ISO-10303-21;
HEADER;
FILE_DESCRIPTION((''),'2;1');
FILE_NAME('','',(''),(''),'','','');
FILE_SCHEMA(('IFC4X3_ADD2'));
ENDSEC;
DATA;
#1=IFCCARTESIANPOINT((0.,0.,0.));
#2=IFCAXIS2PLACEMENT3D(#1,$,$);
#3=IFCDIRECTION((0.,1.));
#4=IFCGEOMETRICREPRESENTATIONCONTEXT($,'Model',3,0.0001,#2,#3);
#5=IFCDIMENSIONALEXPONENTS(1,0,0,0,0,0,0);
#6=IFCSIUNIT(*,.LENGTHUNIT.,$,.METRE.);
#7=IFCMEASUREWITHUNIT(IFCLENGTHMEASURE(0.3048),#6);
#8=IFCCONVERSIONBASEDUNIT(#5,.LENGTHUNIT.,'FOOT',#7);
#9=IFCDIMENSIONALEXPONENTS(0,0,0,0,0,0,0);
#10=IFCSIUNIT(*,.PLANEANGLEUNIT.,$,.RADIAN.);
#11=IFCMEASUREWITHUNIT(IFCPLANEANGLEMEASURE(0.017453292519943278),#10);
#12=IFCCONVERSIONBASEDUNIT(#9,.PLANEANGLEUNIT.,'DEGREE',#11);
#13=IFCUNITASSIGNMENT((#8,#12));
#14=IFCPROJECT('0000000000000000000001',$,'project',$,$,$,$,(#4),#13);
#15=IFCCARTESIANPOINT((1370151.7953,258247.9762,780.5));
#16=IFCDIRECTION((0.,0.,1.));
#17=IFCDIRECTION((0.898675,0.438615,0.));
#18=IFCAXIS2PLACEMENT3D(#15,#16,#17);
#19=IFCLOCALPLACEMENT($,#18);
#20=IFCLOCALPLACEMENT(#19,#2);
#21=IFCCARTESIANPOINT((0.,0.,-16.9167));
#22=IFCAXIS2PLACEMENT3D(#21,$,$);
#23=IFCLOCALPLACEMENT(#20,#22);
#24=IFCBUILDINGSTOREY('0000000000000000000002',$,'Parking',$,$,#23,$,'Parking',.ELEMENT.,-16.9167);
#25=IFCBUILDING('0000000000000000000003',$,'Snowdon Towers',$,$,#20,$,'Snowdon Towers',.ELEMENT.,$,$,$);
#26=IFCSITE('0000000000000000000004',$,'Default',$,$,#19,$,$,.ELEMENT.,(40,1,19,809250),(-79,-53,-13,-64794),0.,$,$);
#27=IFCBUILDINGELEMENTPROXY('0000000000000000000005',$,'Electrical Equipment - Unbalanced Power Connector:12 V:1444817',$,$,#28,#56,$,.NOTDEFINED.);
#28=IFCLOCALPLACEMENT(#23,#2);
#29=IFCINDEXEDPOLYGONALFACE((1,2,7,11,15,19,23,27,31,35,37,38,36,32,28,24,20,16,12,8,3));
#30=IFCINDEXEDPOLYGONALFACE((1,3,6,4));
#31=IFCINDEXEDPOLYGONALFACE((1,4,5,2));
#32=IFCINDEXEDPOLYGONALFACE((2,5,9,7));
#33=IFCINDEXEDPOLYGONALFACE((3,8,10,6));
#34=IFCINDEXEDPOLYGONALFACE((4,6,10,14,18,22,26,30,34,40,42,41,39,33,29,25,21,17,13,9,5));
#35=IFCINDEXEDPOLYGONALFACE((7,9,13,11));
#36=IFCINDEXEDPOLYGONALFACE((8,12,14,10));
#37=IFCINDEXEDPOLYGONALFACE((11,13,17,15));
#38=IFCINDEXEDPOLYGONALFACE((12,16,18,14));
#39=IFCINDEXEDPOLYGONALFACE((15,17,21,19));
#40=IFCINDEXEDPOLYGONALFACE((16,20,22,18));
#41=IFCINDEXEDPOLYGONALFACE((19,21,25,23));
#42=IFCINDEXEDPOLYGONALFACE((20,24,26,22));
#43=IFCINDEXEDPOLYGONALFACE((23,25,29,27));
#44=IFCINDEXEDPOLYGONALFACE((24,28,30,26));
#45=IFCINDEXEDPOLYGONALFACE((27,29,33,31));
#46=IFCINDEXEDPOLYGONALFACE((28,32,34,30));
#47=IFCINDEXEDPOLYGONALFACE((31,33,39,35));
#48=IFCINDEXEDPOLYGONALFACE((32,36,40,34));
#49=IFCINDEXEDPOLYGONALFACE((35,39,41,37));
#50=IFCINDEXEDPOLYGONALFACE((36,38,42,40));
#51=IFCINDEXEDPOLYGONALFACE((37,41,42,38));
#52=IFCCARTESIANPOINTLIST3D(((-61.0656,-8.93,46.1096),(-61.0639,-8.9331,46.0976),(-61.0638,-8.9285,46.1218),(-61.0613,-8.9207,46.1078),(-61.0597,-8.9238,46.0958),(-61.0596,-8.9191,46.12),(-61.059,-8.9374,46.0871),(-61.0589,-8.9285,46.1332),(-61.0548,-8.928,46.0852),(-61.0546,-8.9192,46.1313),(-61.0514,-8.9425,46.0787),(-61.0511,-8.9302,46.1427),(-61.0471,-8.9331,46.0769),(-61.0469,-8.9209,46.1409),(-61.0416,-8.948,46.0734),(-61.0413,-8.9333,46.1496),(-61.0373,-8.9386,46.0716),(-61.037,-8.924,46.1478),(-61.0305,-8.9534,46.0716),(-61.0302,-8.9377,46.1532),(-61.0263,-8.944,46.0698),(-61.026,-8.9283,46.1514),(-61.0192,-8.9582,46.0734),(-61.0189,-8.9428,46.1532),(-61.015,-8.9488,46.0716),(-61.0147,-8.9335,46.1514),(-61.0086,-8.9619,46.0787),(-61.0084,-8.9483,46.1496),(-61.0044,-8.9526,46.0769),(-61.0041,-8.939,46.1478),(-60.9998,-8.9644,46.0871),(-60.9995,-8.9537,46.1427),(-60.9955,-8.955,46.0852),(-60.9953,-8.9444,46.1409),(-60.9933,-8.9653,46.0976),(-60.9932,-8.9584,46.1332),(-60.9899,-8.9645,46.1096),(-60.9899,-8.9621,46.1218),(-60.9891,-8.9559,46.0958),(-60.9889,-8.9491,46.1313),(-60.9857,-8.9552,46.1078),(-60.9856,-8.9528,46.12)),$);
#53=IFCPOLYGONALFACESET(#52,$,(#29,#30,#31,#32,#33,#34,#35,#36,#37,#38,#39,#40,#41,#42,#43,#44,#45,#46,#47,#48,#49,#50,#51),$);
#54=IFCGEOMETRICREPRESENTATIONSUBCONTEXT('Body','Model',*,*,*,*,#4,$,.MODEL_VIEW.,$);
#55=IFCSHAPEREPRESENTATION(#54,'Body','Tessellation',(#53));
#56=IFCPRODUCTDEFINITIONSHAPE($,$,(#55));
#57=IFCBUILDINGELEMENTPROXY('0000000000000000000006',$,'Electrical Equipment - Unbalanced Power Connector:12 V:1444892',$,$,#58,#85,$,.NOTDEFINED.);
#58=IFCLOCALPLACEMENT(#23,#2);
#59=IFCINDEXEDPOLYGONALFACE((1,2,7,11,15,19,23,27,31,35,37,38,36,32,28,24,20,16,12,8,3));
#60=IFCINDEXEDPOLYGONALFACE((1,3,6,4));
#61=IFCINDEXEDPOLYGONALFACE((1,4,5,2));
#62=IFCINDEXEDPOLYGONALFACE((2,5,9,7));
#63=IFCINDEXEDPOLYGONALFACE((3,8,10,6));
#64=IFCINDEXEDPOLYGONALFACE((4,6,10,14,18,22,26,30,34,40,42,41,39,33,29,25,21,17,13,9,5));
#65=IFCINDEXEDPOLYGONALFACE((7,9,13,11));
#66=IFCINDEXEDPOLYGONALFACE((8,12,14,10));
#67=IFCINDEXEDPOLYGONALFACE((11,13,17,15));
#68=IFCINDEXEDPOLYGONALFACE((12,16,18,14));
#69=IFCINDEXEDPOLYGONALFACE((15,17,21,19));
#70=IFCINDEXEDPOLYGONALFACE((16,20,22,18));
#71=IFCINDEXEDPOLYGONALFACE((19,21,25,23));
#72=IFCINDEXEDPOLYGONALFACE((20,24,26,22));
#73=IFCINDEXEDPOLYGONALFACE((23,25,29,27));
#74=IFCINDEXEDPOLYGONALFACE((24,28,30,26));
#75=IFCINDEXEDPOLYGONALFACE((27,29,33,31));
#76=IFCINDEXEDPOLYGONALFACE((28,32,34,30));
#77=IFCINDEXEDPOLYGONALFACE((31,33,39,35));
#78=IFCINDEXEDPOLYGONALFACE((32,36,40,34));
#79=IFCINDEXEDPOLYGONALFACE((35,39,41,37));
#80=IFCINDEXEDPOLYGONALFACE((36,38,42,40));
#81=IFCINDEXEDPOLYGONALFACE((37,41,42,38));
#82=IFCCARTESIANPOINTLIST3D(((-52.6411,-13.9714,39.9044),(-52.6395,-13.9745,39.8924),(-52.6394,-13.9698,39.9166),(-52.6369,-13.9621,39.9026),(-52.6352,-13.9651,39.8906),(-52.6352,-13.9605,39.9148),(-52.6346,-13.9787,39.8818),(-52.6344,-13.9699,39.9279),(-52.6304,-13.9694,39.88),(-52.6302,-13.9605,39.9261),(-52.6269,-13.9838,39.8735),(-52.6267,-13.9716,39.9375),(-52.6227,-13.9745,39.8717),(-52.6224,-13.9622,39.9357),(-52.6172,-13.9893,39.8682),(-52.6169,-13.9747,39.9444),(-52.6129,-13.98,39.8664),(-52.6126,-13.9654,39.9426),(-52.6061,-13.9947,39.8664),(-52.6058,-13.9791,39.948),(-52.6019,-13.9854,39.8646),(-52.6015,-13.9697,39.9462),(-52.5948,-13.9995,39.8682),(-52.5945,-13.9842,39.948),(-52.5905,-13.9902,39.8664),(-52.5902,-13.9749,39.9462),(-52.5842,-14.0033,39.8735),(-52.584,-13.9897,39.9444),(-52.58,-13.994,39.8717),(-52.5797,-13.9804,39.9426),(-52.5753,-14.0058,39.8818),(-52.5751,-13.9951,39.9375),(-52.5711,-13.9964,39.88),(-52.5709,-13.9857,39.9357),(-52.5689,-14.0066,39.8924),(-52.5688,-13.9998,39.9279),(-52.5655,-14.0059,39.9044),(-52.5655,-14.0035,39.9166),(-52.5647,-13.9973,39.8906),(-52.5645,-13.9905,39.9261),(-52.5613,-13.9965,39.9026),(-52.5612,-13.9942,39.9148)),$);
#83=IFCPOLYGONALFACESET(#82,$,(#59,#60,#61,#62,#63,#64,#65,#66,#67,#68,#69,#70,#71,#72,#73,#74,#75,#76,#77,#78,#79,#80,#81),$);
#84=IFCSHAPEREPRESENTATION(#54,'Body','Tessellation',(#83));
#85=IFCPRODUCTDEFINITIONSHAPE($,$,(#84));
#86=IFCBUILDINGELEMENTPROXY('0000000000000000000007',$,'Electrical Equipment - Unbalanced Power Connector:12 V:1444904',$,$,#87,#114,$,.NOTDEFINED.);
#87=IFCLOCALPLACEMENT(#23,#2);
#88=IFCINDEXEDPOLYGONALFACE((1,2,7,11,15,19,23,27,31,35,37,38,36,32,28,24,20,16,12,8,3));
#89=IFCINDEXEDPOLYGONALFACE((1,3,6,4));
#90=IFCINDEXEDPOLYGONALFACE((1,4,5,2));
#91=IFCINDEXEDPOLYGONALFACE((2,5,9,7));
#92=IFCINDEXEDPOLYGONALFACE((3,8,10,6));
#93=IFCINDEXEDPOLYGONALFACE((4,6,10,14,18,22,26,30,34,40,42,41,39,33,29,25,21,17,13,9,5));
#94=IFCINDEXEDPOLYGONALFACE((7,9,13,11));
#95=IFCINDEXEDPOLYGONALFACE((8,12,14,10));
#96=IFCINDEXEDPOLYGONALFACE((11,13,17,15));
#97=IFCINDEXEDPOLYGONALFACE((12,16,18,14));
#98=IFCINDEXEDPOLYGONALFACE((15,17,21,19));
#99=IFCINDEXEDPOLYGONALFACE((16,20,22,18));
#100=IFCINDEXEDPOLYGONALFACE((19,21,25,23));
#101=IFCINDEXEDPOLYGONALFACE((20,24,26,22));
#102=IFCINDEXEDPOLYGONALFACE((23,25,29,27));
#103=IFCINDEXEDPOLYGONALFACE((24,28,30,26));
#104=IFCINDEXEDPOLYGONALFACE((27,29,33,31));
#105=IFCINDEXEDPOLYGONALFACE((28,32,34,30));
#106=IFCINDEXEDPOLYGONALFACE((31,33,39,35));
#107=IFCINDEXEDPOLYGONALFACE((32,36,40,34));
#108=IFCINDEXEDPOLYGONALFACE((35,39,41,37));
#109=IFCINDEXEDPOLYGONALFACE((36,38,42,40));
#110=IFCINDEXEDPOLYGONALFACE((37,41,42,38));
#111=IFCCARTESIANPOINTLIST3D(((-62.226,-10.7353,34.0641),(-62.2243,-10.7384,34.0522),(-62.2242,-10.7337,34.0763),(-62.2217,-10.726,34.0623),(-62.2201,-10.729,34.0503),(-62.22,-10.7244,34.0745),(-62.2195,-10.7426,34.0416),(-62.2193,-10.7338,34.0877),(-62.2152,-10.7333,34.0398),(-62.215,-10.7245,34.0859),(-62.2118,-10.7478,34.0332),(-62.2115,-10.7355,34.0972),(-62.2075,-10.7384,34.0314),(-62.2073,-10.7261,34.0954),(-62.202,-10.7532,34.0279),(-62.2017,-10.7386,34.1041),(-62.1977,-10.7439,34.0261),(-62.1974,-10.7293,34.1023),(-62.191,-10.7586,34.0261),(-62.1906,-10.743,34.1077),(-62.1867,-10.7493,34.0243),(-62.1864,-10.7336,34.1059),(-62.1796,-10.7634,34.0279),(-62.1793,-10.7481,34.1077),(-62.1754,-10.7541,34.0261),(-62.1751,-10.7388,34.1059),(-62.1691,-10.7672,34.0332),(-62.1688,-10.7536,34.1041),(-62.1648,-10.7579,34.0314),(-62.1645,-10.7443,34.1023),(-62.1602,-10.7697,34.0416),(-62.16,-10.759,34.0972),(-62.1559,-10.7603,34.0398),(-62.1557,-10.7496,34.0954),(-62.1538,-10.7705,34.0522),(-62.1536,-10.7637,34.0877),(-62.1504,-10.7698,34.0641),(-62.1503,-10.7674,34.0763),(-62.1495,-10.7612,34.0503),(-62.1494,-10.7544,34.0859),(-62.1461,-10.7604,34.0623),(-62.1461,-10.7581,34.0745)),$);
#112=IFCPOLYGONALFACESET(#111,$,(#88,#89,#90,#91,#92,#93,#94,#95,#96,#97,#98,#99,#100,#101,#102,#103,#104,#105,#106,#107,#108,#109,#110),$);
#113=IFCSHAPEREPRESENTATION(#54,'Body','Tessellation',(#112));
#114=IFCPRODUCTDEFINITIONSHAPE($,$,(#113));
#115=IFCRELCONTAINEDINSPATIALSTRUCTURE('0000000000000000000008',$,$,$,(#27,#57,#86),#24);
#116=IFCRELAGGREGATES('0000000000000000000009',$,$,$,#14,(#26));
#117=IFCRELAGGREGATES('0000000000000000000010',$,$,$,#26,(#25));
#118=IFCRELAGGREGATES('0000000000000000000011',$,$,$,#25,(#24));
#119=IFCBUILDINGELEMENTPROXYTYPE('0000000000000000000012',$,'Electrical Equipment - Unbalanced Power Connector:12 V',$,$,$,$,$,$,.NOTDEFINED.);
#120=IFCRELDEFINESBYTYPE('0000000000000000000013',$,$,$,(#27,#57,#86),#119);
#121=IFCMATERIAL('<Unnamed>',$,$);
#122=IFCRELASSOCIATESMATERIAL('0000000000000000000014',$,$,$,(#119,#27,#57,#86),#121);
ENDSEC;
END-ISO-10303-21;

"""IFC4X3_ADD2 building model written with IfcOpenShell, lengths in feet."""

from ifc_helpers import new_model, entity, si_unit, converted_unit, direction, frame, frame_2d, origin, place, context, subcontext, project, spatial, circle, extrude, source, transform, mapped, material, type_object, type_shapes, element, save


model = new_model("IFC4X3_ADD2")

# Units and contexts
model_context = context("Model", 3, precision=0.0001, world=origin(), true_north=direction((0.0, 1.0)))
body_context = subcontext(model_context, "Body", "Model", "MODEL_VIEW")
ifc_project = project(units=[converted_unit("LENGTHUNIT", "FOOT", entity("IfcLengthMeasure", 0.3048), si_unit("LENGTHUNIT", "METRE"), dimensions=[1, 0, 0, 0, 0, 0, 0]), converted_unit("PLANEANGLEUNIT", "DEGREE", entity("IfcPlaneAngleMeasure", 0.017453292519943278), si_unit("PLANEANGLEUNIT", "RADIAN"), dimensions=[0, 0, 0, 0, 0, 0, 0])], contexts=[model_context])

# Site, building, storey
site_placement = place(None, frame((1370151.7953, 258247.9762, 780.5), z_axis=(0.0, 0.0, 1.0), x_axis=(0.898675, 0.438615, 0.0)))
site = spatial("IfcSite", under=ifc_project, at=site_placement, Name="Default", CompositionType="ELEMENT", RefLatitude=(40, 1, 19, 809250), RefLongitude=(-79, -53, -13, -64794), RefElevation=0.0)
building_placement = place(site_placement, origin())
building = spatial("IfcBuilding", under=site, at=building_placement, Name="Snowdon Towers", LongName="Snowdon Towers", CompositionType="ELEMENT")
storey_placement = place(building_placement, frame((0.0, 0.0, -16.9167)))
storey = spatial("IfcBuildingStorey", under=building, at=storey_placement, Name="Parking", LongName="Parking", CompositionType="ELEMENT", Elevation=-16.9167)

# Building element proxies
ifc_material_1 = material(Name="<Unnamed>")
building_element_proxy_type = type_object("IfcBuildingElementProxyType", Name="Electrical Equipment - Unbalanced Power Connector:12 V", PredefinedType="NOTDEFINED", material=ifc_material_1)
shared_shape_1 = source(origin(), body_context, "Body", "SweptSolid", [
    extrude(circle(Radius=0.0417, at=frame_2d((0.0, 0.0), x_axis=(1.0, 0.0))), origin(), (0.0, 0.0, 1.0), 0.0104),
])
type_shapes(building_element_proxy_type, [shared_shape_1])
for number, where, z_axis, x_axis, name in (
    (1, (-61.0275, -8.9468, 46.1126), (0.408371, 0.896147, -0.173648), (-0.072007, -0.158015, -0.984808), "Electrical Equipment - Unbalanced Power Connector:12 V:1444817"),
    (2, (-52.6031, -13.9881, 39.9074), (0.408371, 0.896147, -0.173648), (-0.072007, -0.158015, -0.984808), "Electrical Equipment - Unbalanced Power Connector:12 V:1444892"),
    (3, (-62.188, -10.752, 34.0671), (0.408371, 0.896147, -0.173648), (-0.072007, -0.158015, -0.984808), "Electrical Equipment - Unbalanced Power Connector:12 V:1444904"),
):
    element("IfcBuildingElementProxy", number, at=place(storey_placement, frame(where, z_axis=z_axis, x_axis=x_axis)), inside=storey, type_object=building_element_proxy_type, material=ifc_material_1, Name=name, PredefinedType="NOTDEFINED", context=body_context, shape_type="MappedRepresentation", body=[
        mapped(shared_shape_1, transform((0.0, 0.0, 0.0), scale=1.0)),
    ])

save(model, "model.ifc")
